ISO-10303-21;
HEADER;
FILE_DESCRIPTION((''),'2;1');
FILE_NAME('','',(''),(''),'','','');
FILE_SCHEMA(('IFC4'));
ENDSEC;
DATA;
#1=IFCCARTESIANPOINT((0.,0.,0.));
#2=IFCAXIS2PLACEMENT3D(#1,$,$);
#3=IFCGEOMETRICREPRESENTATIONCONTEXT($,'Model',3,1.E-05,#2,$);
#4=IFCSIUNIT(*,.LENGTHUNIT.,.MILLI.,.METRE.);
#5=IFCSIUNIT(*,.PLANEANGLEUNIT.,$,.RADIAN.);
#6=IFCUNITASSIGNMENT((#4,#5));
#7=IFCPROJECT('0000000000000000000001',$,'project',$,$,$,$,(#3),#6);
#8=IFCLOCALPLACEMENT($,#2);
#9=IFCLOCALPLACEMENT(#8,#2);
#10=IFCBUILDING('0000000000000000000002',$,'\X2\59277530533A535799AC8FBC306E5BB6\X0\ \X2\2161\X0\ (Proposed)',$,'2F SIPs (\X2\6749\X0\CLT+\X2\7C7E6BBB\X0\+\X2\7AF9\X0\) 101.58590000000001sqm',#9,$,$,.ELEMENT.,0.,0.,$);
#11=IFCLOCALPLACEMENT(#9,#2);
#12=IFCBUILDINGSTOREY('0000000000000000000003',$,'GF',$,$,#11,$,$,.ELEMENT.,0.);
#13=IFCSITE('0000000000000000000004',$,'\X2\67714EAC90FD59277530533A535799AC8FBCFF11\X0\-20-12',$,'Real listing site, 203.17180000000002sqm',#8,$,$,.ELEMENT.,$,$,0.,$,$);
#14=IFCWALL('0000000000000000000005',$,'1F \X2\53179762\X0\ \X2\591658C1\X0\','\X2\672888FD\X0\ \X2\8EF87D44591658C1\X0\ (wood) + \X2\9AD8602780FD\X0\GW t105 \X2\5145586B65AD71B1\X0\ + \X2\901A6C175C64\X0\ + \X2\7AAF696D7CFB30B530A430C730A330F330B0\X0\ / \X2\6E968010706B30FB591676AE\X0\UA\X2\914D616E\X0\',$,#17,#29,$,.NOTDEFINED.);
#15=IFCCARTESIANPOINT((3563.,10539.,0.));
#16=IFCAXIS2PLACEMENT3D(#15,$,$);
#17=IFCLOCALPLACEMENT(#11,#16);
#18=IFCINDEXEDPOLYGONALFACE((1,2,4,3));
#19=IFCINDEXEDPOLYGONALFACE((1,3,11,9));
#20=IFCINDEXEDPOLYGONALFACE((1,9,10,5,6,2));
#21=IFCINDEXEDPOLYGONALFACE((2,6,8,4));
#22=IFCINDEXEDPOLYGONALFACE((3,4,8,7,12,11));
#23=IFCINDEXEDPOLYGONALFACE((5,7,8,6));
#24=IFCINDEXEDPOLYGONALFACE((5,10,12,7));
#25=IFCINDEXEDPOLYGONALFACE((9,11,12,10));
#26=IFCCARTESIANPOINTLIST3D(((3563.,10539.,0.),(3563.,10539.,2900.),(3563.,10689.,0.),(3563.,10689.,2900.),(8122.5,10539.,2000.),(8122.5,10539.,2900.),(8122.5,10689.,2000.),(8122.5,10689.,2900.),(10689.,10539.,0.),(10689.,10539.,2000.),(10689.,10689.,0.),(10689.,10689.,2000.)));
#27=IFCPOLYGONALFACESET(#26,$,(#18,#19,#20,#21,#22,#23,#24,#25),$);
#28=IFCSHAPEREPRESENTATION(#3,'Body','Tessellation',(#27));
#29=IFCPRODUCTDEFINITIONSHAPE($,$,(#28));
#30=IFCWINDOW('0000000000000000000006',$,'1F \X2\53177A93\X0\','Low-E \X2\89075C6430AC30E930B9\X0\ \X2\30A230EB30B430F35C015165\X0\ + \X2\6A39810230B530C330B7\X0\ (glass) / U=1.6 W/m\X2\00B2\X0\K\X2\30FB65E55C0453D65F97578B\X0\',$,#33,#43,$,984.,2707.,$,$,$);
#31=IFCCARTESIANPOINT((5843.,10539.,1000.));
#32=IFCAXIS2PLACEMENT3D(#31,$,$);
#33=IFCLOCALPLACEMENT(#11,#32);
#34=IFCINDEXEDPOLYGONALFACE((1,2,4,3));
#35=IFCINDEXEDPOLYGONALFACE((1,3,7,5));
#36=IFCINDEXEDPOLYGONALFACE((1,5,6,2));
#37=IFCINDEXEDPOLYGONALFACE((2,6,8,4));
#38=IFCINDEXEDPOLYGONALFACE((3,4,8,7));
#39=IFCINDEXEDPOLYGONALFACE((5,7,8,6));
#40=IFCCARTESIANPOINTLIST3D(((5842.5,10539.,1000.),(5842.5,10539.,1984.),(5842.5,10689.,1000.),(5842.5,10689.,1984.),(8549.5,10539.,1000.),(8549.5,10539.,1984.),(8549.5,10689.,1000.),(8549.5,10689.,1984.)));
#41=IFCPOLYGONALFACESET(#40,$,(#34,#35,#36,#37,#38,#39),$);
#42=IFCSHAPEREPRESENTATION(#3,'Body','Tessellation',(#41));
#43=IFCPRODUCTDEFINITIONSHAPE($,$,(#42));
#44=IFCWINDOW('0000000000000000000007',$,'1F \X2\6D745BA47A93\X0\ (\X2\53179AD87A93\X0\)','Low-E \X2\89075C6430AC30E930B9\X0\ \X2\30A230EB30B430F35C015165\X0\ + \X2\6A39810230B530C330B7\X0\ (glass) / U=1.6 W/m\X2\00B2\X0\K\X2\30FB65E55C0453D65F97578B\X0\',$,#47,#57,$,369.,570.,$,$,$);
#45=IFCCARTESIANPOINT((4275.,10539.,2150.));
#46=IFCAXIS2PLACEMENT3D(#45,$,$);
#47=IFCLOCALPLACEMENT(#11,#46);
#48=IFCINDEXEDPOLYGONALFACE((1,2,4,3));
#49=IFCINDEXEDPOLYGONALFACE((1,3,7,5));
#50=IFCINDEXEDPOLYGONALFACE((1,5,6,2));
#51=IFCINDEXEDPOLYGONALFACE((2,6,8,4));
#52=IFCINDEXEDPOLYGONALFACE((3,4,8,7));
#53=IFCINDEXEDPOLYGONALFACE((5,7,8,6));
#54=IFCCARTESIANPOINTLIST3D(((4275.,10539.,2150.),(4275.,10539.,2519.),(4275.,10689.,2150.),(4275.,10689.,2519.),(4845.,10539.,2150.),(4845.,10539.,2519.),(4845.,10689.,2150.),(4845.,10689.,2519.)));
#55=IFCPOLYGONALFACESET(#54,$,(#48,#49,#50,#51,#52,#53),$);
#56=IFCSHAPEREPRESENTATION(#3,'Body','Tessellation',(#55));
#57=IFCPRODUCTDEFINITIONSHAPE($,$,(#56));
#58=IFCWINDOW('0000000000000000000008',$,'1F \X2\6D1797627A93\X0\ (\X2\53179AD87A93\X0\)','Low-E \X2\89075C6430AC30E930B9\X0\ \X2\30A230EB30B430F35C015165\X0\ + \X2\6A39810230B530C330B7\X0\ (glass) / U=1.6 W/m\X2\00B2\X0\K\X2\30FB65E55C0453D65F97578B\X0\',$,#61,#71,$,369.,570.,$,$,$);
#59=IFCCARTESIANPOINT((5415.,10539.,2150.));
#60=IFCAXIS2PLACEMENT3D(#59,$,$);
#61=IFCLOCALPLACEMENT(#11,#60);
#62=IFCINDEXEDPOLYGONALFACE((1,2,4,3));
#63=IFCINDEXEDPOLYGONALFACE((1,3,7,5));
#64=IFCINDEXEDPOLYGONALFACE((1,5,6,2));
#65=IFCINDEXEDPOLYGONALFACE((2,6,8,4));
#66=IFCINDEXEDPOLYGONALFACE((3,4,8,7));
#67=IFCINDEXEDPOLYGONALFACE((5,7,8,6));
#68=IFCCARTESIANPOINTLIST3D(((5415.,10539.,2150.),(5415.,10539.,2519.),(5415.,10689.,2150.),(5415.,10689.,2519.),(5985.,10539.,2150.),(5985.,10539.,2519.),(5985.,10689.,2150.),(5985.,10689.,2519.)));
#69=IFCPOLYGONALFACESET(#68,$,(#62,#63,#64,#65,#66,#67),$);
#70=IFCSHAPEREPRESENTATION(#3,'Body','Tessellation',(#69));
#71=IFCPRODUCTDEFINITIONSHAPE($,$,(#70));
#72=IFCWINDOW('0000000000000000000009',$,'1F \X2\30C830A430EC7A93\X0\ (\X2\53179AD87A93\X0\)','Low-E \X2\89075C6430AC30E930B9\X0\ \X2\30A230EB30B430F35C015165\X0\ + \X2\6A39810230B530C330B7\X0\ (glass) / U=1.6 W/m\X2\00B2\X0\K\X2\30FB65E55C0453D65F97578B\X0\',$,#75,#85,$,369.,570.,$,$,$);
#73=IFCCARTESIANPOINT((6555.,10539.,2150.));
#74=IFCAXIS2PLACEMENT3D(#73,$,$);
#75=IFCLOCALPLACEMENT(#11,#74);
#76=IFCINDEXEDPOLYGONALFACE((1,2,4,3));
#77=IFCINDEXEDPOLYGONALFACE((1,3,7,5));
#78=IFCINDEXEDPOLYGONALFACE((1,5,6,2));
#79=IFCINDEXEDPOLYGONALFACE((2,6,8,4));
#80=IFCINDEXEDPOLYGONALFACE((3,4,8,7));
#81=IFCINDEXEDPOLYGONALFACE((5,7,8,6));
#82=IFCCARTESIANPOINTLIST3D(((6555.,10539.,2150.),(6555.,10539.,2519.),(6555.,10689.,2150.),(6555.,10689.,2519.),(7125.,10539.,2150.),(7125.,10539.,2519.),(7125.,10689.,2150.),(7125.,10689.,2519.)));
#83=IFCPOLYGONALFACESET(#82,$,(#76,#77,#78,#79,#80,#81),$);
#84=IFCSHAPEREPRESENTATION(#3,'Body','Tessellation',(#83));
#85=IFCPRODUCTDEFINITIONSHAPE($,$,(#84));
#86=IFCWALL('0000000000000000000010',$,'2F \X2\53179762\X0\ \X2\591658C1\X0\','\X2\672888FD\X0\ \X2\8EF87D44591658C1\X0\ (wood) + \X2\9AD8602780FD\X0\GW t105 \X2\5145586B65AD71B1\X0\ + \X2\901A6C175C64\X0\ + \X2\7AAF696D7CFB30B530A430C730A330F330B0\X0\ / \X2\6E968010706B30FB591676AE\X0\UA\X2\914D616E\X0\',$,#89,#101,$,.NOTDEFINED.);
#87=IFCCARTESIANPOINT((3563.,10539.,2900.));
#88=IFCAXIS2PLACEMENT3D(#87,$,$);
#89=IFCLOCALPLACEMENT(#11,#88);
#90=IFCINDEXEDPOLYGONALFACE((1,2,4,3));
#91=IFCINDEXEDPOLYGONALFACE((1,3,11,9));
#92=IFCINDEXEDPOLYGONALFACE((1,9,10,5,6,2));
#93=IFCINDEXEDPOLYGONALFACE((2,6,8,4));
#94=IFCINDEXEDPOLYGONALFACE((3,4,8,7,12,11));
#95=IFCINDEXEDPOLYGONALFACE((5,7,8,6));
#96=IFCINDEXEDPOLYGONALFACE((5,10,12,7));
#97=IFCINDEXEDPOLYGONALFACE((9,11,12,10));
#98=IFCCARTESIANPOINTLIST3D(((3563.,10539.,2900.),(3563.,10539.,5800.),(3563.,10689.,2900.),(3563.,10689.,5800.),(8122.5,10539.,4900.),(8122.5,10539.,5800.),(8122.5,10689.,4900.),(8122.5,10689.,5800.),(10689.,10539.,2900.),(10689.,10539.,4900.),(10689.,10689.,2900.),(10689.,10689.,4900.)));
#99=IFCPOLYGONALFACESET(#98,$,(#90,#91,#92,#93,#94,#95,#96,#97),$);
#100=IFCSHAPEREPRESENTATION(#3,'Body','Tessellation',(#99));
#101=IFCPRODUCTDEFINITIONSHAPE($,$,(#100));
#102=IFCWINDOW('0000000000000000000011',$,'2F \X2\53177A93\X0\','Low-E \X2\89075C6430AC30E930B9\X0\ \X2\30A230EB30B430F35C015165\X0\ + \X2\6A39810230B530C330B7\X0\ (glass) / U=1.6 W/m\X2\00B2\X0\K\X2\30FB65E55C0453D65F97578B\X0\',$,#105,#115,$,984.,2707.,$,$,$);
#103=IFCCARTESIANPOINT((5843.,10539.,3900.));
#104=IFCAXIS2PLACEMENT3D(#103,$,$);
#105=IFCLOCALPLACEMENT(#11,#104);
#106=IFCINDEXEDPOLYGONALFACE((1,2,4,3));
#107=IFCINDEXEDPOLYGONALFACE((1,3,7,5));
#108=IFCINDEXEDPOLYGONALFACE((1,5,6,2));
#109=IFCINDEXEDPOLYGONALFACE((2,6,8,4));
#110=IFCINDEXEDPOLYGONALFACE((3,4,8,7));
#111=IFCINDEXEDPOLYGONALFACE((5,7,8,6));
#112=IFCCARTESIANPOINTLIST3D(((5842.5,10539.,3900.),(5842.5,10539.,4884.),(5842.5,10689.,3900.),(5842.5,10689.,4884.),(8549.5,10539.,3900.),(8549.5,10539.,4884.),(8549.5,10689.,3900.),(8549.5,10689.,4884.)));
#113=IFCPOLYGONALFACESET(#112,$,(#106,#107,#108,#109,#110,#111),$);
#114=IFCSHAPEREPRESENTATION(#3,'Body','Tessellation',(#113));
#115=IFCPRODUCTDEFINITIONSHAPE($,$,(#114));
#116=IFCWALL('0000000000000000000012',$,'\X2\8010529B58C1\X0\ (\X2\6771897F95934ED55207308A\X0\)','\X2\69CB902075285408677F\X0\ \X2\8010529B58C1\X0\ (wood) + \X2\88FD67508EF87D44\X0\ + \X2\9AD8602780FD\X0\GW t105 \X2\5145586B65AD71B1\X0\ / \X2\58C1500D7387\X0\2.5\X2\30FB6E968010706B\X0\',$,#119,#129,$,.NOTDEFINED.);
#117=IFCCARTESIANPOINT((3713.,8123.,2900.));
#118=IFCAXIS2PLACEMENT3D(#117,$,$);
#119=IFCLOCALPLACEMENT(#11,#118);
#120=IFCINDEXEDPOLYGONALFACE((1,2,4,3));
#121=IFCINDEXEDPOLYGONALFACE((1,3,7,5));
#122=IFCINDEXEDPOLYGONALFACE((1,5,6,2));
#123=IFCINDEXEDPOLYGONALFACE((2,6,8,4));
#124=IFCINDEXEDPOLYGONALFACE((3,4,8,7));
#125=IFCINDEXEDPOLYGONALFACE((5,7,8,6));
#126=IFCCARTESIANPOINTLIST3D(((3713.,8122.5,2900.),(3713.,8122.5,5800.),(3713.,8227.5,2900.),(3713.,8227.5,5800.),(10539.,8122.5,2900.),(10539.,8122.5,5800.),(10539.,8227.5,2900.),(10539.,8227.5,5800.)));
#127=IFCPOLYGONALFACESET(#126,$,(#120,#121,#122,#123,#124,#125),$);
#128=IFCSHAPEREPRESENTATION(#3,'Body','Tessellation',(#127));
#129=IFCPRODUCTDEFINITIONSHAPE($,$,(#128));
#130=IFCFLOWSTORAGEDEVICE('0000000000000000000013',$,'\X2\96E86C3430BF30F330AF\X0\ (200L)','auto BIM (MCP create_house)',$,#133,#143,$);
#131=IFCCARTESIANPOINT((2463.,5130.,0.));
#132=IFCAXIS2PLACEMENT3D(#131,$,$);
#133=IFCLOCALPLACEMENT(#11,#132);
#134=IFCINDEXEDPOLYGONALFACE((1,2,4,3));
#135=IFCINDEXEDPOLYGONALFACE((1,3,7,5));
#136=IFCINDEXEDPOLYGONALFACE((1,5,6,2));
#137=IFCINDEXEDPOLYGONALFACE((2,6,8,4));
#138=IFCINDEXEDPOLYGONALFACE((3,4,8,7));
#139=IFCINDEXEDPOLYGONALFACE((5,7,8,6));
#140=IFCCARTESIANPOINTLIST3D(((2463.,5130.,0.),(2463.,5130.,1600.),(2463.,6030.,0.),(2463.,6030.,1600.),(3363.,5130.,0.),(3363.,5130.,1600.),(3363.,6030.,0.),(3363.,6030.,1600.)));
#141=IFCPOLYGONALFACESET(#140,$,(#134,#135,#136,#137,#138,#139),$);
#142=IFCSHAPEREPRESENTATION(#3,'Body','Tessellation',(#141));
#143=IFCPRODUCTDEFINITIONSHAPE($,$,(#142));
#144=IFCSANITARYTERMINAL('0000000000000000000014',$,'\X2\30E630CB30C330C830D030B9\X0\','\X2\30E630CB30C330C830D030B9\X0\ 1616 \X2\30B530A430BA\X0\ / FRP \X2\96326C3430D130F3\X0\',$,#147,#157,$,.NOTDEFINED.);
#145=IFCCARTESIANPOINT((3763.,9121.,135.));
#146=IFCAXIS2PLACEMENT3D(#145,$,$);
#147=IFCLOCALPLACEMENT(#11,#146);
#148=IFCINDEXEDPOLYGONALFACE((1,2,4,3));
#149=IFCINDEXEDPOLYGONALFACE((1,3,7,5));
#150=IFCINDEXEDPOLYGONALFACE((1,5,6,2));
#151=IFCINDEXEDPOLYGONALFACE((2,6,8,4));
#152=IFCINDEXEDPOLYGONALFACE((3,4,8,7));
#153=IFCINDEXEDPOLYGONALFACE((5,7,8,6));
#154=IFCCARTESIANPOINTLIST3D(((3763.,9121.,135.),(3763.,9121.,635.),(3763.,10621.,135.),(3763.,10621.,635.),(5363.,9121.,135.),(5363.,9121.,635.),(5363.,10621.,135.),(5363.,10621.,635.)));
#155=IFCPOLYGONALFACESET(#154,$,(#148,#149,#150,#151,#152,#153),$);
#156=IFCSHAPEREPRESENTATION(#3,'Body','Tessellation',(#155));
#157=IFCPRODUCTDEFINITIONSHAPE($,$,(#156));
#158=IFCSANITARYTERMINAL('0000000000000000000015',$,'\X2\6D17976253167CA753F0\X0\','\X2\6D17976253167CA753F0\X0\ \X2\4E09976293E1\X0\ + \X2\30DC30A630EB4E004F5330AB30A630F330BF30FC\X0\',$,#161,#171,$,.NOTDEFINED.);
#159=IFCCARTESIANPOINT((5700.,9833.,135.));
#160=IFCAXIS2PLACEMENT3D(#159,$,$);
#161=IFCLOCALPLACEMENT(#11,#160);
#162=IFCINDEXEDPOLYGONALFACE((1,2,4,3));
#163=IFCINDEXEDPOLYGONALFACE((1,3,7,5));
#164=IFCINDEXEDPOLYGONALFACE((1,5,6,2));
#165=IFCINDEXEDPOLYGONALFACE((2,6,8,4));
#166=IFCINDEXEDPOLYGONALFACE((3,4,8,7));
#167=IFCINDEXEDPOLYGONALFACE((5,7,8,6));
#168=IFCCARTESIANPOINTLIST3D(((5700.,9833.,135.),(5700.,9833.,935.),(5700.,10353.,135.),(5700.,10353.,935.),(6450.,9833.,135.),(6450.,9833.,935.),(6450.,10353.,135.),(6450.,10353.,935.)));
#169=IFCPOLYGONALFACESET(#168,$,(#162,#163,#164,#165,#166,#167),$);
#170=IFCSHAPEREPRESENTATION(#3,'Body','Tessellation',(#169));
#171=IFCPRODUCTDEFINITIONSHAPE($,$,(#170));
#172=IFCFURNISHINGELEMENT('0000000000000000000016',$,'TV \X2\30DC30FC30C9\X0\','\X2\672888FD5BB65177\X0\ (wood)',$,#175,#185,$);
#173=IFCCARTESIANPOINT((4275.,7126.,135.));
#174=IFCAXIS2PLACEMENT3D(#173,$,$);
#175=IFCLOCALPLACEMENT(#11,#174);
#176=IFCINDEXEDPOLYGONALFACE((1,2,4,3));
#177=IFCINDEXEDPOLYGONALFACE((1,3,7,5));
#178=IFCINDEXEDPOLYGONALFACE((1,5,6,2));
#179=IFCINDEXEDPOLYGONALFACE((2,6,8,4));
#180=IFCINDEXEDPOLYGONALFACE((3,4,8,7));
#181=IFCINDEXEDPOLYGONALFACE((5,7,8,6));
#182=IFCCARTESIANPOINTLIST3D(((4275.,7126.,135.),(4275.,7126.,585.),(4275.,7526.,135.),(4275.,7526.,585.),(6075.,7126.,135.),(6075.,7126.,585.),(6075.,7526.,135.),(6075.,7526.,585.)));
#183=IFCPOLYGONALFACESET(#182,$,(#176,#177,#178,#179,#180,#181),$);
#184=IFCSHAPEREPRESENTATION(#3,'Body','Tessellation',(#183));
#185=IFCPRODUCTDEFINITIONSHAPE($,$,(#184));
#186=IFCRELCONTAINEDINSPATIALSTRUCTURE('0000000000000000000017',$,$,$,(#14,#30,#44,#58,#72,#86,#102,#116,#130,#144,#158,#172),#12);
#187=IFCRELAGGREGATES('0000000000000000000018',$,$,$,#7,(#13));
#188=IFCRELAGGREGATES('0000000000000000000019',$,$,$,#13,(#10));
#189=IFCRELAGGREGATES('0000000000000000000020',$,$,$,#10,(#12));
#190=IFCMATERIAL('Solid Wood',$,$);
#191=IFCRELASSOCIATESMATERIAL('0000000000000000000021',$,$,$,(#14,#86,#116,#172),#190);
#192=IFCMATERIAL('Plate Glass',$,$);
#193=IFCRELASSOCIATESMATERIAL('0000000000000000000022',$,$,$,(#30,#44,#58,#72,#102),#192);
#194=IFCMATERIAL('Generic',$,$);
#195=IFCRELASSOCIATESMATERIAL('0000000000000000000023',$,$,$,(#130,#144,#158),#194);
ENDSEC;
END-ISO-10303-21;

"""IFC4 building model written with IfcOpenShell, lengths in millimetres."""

from ifc_helpers import new_model, si_unit, frame, frame_2d, origin, place, context, project, spatial, rectangle, extrude, material, element, fill, save


model = new_model("IFC4")

# Units and contexts
model_context = context("Model", 3, precision=1e-05, world=origin())
ifc_project = project(units=[si_unit("LENGTHUNIT", "METRE", prefix="MILLI"), si_unit("PLANEANGLEUNIT", "RADIAN")], contexts=[model_context])

# Site, building, storey
site_placement = place(None, origin())
site = spatial("IfcSite", under=ifc_project, at=site_placement, Name="東京都大田区南馬込１-20-12", ObjectType="Real listing site, 203.17180000000002sqm", CompositionType="ELEMENT", RefElevation=0.0)
building_placement = place(site_placement, origin())
building = spatial("IfcBuilding", under=site, at=building_placement, Name="大田区南馬込の家 Ⅱ (Proposed)", ObjectType="2F SIPs (杉CLT+籾殻+竹) 101.58590000000001sqm", CompositionType="ELEMENT", ElevationOfRefHeight=0.0, ElevationOfTerrain=0.0)
storey_placement = place(building_placement, origin())
storey = spatial("IfcBuildingStorey", under=building, at=storey_placement, Name="GF", CompositionType="ELEMENT", Elevation=0.0)

# Wall, openings, windows
ifc_material_1 = material(Name="Solid Wood")
wall_1_placement = place(storey_placement, frame((3563.0, 10539.0, 0.0)))
wall_1 = element("IfcWall", 1, at=wall_1_placement, inside=storey, material=ifc_material_1, Name="1F 北面 外壁", Description="木製 軸組外壁 (wood) + 高性能GW t105 充填断熱 + 通気層 + 窯業系サイディング / 準耐火・外皮UA配慮", PredefinedType="NOTDEFINED", context=model_context, shape_type="SweptSolid", body=[
    extrude(rectangle(XDim=7126.0, YDim=150.0, at=frame_2d((3563.0, 75.0))), frame((3563.0, 10539.0, 0.0)), (0.0, 0.0, 1.0), 2900.0),
])
opening_1_placement = place(storey_placement, frame((5843.0, 10539.0, 1000.0)))
opening_1 = element("IfcOpeningElement", 2, at=opening_1_placement, cuts=wall_1, PredefinedType="NOTDEFINED", context=model_context, shape_type="SweptSolid", body=[
    extrude(rectangle(XDim=2707.0, YDim=150.0, at=frame_2d((1353.0, 75.0))), frame((5843.0, 10539.0, 1000.0)), (0.0, 0.0, 1.0), 984.0),
])
opening_2_placement = place(storey_placement, frame((4275.0, 10539.0, 2150.0)))
opening_2 = element("IfcOpeningElement", 3, at=opening_2_placement, cuts=wall_1, PredefinedType="NOTDEFINED", context=model_context, shape_type="SweptSolid", body=[
    extrude(rectangle(XDim=570.0, YDim=150.0, at=frame_2d((285.0, 75.0))), frame((4275.0, 10539.0, 2150.0)), (0.0, 0.0, 1.0), 369.0),
])
opening_3_placement = place(storey_placement, frame((5415.0, 10539.0, 2150.0)))
opening_3 = element("IfcOpeningElement", 4, at=opening_3_placement, cuts=wall_1, PredefinedType="NOTDEFINED", context=model_context, shape_type="SweptSolid", body=[
    extrude(rectangle(XDim=570.0, YDim=150.0, at=frame_2d((285.0, 75.0))), frame((5415.0, 10539.0, 2150.0)), (0.0, 0.0, 1.0), 369.0),
])
opening_4_placement = place(storey_placement, frame((6555.0, 10539.0, 2150.0)))
opening_4 = element("IfcOpeningElement", 5, at=opening_4_placement, cuts=wall_1, PredefinedType="NOTDEFINED", context=model_context, shape_type="SweptSolid", body=[
    extrude(rectangle(XDim=570.0, YDim=150.0, at=frame_2d((285.0, 75.0))), frame((6555.0, 10539.0, 2150.0)), (0.0, 0.0, 1.0), 369.0),
])
ifc_material_2 = material(Name="Plate Glass")
window_1_placement = place(storey_placement, frame((5843.0, 10539.0, 1000.0)))
window_1 = element("IfcWindow", 6, at=window_1_placement, inside=storey, material=ifc_material_2, Name="1F 北窓", Description="Low-E 複層ガラス アルゴン封入 + 樹脂サッシ (glass) / U=1.6 W/m²K・日射取得型", OverallHeight=984.0, OverallWidth=2707.0, context=model_context, shape_type="SweptSolid", body=[
    extrude(rectangle(XDim=2707.0, YDim=150.0, at=frame_2d((1353.0, 75.0))), frame((5843.0, 10539.0, 1000.0)), (0.0, 0.0, 1.0), 984.0),
])
fill(opening_1, window_1)
window_2_placement = place(storey_placement, frame((4275.0, 10539.0, 2150.0)))
window_2 = element("IfcWindow", 7, at=window_2_placement, inside=storey, material=ifc_material_2, Name="1F 浴室窓 (北高窓)", Description="Low-E 複層ガラス アルゴン封入 + 樹脂サッシ (glass) / U=1.6 W/m²K・日射取得型", OverallHeight=369.0, OverallWidth=570.0, context=model_context, shape_type="SweptSolid", body=[
    extrude(rectangle(XDim=570.0, YDim=150.0, at=frame_2d((285.0, 75.0))), frame((4275.0, 10539.0, 2150.0)), (0.0, 0.0, 1.0), 369.0),
])
fill(opening_2, window_2)
window_3_placement = place(storey_placement, frame((5415.0, 10539.0, 2150.0)))
window_3 = element("IfcWindow", 8, at=window_3_placement, inside=storey, material=ifc_material_2, Name="1F 洗面窓 (北高窓)", Description="Low-E 複層ガラス アルゴン封入 + 樹脂サッシ (glass) / U=1.6 W/m²K・日射取得型", OverallHeight=369.0, OverallWidth=570.0, context=model_context, shape_type="SweptSolid", body=[
    extrude(rectangle(XDim=570.0, YDim=150.0, at=frame_2d((285.0, 75.0))), frame((5415.0, 10539.0, 2150.0)), (0.0, 0.0, 1.0), 369.0),
])
fill(opening_3, window_3)
window_4_placement = place(storey_placement, frame((6555.0, 10539.0, 2150.0)))
window_4 = element("IfcWindow", 9, at=window_4_placement, inside=storey, material=ifc_material_2, Name="1F トイレ窓 (北高窓)", Description="Low-E 複層ガラス アルゴン封入 + 樹脂サッシ (glass) / U=1.6 W/m²K・日射取得型", OverallHeight=369.0, OverallWidth=570.0, context=model_context, shape_type="SweptSolid", body=[
    extrude(rectangle(XDim=570.0, YDim=150.0, at=frame_2d((285.0, 75.0))), frame((6555.0, 10539.0, 2150.0)), (0.0, 0.0, 1.0), 369.0),
])
fill(opening_4, window_4)

# Wall, opening, window
wall_2_placement = place(storey_placement, frame((3563.0, 10539.0, 2900.0)))
wall_2 = element("IfcWall", 10, at=wall_2_placement, inside=storey, material=ifc_material_1, Name="2F 北面 外壁", Description="木製 軸組外壁 (wood) + 高性能GW t105 充填断熱 + 通気層 + 窯業系サイディング / 準耐火・外皮UA配慮", PredefinedType="NOTDEFINED", context=model_context, shape_type="SweptSolid", body=[
    extrude(rectangle(XDim=7126.0, YDim=150.0, at=frame_2d((3563.0, 75.0))), frame((3563.0, 10539.0, 2900.0)), (0.0, 0.0, 1.0), 2900.0),
])
opening_5_placement = place(storey_placement, frame((5843.0, 10539.0, 3900.0)))
opening_5 = element("IfcOpeningElement", 11, at=opening_5_placement, cuts=wall_2, PredefinedType="NOTDEFINED", context=model_context, shape_type="SweptSolid", body=[
    extrude(rectangle(XDim=2707.0, YDim=150.0, at=frame_2d((1353.0, 75.0))), frame((5843.0, 10539.0, 3900.0)), (0.0, 0.0, 1.0), 984.0),
])
window_5_placement = place(storey_placement, frame((5843.0, 10539.0, 3900.0)))
window_5 = element("IfcWindow", 12, at=window_5_placement, inside=storey, material=ifc_material_2, Name="2F 北窓", Description="Low-E 複層ガラス アルゴン封入 + 樹脂サッシ (glass) / U=1.6 W/m²K・日射取得型", OverallHeight=984.0, OverallWidth=2707.0, context=model_context, shape_type="SweptSolid", body=[
    extrude(rectangle(XDim=2707.0, YDim=150.0, at=frame_2d((1353.0, 75.0))), frame((5843.0, 10539.0, 3900.0)), (0.0, 0.0, 1.0), 984.0),
])
fill(opening_5, window_5)

# Wall
wall_3_placement = place(storey_placement, frame((3713.0, 8123.0, 2900.0)))
element("IfcWall", 13, at=wall_3_placement, inside=storey, material=ifc_material_1, Name="耐力壁 (東西間仕切り)", Description="構造用合板 耐力壁 (wood) + 製材軸組 + 高性能GW t105 充填断熱 / 壁倍率2.5・準耐火", PredefinedType="NOTDEFINED", context=model_context, shape_type="SweptSolid", body=[
    extrude(rectangle(XDim=6826.0, YDim=105.0, at=frame_2d((3413.0, 52.0))), frame((3713.0, 8123.0, 2900.0)), (0.0, 0.0, 1.0), 2900.0),
])

# Flow storage device
ifc_material_3 = material(Name="Generic")
flow_storage_device_placement = place(storey_placement, frame((2463.0, 5130.0, 0.0)))
element("IfcFlowStorageDevice", 14, at=flow_storage_device_placement, inside=storey, material=ifc_material_3, Name="雨水タンク (200L)", Description="auto BIM (MCP create_house)", context=model_context, shape_type="SweptSolid", body=[
    extrude(rectangle(XDim=900.0, YDim=900.0, at=frame_2d((450.0, 450.0))), frame((2463.0, 5130.0, 0.0)), (0.0, 0.0, 1.0), 1600.0),
])

# Sanitary terminals
sanitary_terminal_1_placement = place(storey_placement, frame((3763.0, 9121.0, 135.0)))
element("IfcSanitaryTerminal", 15, at=sanitary_terminal_1_placement, inside=storey, material=ifc_material_3, Name="ユニットバス", Description="ユニットバス 1616 サイズ / FRP 防水パン", PredefinedType="NOTDEFINED", context=model_context, shape_type="SweptSolid", body=[
    extrude(rectangle(XDim=1600.0, YDim=1500.0, at=frame_2d((800.0, 750.0))), frame((3763.0, 9121.0, 135.0)), (0.0, 0.0, 1.0), 500.0),
])
sanitary_terminal_2_placement = place(storey_placement, frame((5700.0, 9833.0, 135.0)))
element("IfcSanitaryTerminal", 16, at=sanitary_terminal_2_placement, inside=storey, material=ifc_material_3, Name="洗面化粧台", Description="洗面化粧台 三面鏡 + ボウル一体カウンター", PredefinedType="NOTDEFINED", context=model_context, shape_type="SweptSolid", body=[
    extrude(rectangle(XDim=750.0, YDim=520.0, at=frame_2d((375.0, 260.0))), frame((5700.0, 9833.0, 135.0)), (0.0, 0.0, 1.0), 800.0),
])

# Furnishing element
furnishing_1_placement = place(storey_placement, frame((4275.0, 7126.0, 135.0)))
element("IfcFurnishingElement", 17, at=furnishing_1_placement, inside=storey, material=ifc_material_1, Name="TV ボード", Description="木製家具 (wood)", context=model_context, shape_type="SweptSolid", body=[
    extrude(rectangle(XDim=1800.0, YDim=400.0, at=frame_2d((900.0, 200.0))), frame((4275.0, 7126.0, 135.0)), (0.0, 0.0, 1.0), 450.0),
])

save(model, "model.ifc")
